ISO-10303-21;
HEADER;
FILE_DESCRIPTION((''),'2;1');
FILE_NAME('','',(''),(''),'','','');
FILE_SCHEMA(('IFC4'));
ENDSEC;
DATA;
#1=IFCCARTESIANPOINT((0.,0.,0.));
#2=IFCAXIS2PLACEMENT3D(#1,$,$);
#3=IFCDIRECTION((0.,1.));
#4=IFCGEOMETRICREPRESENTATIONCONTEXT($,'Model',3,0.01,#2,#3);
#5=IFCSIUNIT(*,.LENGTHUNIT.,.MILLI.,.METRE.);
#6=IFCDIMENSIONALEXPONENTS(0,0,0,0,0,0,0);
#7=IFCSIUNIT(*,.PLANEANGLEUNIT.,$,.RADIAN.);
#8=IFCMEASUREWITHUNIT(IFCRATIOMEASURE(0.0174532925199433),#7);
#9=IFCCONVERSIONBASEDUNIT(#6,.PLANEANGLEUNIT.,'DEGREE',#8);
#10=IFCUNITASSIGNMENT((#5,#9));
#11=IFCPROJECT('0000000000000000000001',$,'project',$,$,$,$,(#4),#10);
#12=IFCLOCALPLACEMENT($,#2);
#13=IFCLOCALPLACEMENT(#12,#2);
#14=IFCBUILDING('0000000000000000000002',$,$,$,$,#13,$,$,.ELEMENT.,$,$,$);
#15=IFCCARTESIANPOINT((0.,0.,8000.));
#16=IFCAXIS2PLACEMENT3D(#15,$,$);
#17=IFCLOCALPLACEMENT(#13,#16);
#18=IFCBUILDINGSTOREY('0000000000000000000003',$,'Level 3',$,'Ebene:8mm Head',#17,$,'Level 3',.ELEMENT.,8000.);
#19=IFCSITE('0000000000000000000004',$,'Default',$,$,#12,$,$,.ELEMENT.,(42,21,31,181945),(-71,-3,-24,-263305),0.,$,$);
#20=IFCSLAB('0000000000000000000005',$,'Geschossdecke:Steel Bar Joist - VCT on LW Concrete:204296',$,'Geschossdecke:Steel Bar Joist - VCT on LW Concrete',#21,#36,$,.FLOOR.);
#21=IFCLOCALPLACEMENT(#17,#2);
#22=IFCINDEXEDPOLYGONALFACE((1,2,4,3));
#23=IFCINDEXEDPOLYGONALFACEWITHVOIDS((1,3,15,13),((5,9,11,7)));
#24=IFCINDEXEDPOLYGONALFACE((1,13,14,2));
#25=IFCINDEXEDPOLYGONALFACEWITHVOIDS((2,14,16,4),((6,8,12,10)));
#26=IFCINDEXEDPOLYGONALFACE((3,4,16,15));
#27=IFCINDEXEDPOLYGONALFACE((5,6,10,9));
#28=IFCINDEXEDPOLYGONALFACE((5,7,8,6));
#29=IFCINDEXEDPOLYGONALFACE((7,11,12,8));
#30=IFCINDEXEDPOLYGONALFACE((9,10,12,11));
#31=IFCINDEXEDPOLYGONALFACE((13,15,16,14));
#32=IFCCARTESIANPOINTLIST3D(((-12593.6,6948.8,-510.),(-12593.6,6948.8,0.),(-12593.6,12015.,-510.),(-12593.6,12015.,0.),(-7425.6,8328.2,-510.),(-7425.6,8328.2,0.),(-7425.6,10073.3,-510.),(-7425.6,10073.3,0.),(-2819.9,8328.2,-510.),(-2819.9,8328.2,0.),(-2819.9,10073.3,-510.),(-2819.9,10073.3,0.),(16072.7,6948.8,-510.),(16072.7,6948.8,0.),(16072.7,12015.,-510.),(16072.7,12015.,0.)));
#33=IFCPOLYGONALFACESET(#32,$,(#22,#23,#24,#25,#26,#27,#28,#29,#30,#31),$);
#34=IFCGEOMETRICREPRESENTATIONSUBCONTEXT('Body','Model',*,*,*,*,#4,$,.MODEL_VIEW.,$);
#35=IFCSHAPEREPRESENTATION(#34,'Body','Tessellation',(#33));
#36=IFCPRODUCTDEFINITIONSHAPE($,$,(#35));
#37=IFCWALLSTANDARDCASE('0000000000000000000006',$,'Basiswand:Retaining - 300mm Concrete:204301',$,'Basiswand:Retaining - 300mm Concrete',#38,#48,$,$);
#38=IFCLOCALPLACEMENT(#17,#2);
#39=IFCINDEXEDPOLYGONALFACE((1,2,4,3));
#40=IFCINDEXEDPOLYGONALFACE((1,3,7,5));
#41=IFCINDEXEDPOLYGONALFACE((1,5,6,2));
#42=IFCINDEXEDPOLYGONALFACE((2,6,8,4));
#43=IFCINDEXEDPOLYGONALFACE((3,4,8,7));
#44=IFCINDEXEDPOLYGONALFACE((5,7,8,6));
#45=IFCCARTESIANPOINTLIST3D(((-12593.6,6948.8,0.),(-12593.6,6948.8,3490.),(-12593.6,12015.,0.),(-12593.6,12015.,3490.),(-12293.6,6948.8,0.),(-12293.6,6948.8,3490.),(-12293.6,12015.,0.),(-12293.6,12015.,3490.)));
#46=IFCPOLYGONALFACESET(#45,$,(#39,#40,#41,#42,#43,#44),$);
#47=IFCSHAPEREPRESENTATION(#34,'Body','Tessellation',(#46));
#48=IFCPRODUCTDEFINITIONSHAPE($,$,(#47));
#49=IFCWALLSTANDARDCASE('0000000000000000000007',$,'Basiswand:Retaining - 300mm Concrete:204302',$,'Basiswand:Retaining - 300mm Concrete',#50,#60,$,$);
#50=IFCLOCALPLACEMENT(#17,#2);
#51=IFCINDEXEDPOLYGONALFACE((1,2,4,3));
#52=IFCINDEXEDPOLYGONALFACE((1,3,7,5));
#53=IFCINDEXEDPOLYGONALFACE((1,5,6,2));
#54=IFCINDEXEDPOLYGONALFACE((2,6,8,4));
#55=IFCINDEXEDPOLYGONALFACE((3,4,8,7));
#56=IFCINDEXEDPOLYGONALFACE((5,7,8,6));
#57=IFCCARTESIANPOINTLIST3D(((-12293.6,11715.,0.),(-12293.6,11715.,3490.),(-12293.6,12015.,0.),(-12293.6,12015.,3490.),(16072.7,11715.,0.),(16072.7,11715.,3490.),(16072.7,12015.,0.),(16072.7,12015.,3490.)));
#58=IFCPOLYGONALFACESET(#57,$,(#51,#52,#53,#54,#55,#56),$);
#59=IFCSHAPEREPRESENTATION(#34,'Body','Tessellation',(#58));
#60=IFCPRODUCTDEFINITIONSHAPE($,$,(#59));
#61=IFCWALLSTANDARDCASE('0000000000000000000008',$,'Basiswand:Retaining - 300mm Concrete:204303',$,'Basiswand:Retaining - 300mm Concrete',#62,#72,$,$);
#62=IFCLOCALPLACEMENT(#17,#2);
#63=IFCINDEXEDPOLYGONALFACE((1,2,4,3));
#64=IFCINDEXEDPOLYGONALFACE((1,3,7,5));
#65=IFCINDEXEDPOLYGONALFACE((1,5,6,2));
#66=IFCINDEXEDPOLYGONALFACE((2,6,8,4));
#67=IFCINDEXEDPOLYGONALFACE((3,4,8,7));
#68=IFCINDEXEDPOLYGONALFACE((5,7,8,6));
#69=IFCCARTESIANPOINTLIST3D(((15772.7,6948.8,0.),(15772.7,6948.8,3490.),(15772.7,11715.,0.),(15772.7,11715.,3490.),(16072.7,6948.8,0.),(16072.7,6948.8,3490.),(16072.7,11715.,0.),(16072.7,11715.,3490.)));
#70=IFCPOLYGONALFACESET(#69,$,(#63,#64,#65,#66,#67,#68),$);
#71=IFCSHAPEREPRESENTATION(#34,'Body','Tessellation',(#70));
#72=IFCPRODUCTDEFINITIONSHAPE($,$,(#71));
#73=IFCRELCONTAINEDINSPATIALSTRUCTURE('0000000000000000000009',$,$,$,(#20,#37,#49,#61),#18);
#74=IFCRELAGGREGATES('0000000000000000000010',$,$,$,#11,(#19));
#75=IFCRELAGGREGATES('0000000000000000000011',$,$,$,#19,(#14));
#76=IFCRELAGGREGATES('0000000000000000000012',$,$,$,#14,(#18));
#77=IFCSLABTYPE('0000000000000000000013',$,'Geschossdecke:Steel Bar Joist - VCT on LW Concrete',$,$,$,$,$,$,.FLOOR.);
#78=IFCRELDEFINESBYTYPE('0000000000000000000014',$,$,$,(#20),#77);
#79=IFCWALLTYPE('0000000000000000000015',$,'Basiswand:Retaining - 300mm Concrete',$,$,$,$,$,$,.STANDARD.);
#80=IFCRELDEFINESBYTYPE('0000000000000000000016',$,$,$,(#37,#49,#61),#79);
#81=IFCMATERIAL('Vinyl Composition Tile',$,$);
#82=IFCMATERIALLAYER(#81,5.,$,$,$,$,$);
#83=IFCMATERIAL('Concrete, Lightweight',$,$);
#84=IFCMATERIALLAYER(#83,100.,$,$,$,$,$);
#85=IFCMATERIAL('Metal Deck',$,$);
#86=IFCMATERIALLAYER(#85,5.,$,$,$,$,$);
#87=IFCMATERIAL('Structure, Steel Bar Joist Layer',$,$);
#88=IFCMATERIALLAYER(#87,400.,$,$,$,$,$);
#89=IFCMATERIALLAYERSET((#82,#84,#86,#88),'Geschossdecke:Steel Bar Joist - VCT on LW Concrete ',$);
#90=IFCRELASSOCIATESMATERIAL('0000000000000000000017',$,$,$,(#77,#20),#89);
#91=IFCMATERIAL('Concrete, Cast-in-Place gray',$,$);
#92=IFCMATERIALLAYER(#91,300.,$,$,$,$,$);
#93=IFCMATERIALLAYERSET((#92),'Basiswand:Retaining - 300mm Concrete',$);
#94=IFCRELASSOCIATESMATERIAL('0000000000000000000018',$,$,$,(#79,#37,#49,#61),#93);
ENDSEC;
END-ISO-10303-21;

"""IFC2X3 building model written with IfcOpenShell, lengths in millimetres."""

from ifc_helpers import new_model, entity, si_unit, converted_unit, direction, frame, frame_2d, origin, origin_2d_with_axis, place, context, subcontext, project, spatial, polyline, rectangle, extrude, clip, bounded_halfspace, material, layer, layer_set, layer_usage, type_object, element, save


model = new_model("IFC2X3")

# Units and contexts
model_context = context("Model", 3, precision=0.01, world=origin(), true_north=direction((0.0, 1.0)))
body_context = subcontext(model_context, "Body", "Model", "MODEL_VIEW")
ifc_project = project(units=[si_unit("LENGTHUNIT", "METRE", prefix="MILLI"), converted_unit("PLANEANGLEUNIT", "DEGREE", entity("IfcRatioMeasure", 0.0174532925199433), si_unit("PLANEANGLEUNIT", "RADIAN"), dimensions=[0, 0, 0, 0, 0, 0, 0])], contexts=[model_context])

# Site, building, storey
site_placement = place(None, origin())
site = spatial("IfcSite", under=ifc_project, at=site_placement, Name="Default", CompositionType="ELEMENT", RefLatitude=(42, 21, 31, 181945), RefLongitude=(-71, -3, -24, -263305), RefElevation=0.0)
building_placement = place(site_placement, origin())
building = spatial("IfcBuilding", under=site, at=building_placement, CompositionType="ELEMENT")
storey_placement = place(building_placement, frame((0.0, 0.0, 8000.0)))
storey = spatial("IfcBuildingStorey", under=building, at=storey_placement, Name="Level 3", ObjectType="Ebene:8mm Head", LongName="Level 3", CompositionType="ELEMENT", Elevation=8000.0)

# Slab, opening
ifc_material_1 = material(Name="Vinyl Composition Tile")
ifc_layer_1 = layer(ifc_material_1, 5.0)
ifc_material_2 = material(Name="Concrete, Lightweight")
ifc_layer_2 = layer(ifc_material_2, 100.0)
ifc_material_3 = material(Name="Metal Deck")
ifc_layer_3 = layer(ifc_material_3, 5.0)
ifc_material_4 = material(Name="Structure, Steel Bar Joist Layer")
ifc_layer_4 = layer(ifc_material_4, 400.0)
ifc_layer_set_1 = layer_set([ifc_layer_1, ifc_layer_2, ifc_layer_3, ifc_layer_4], Name="Geschossdecke:Steel Bar Joist - VCT on LW Concrete ")
ifc_layer_usage_1 = layer_usage(ifc_layer_set_1, "AXIS3", "POSITIVE", 0.0)
slab_type = type_object("IfcSlabType", Name="Geschossdecke:Steel Bar Joist - VCT on LW Concrete", PredefinedType="FLOOR", material=ifc_layer_set_1)
slab_placement = place(storey_placement, frame((-12593.6, 6948.8, -510.0)))
slab = element("IfcSlab", 1, at=slab_placement, inside=storey, type_object=slab_type, material=ifc_layer_usage_1, Name="Geschossdecke:Steel Bar Joist - VCT on LW Concrete:204296", ObjectType="Geschossdecke:Steel Bar Joist - VCT on LW Concrete", PredefinedType="FLOOR", context=body_context, shape_type="SweptSolid", body=[
    extrude(rectangle(XDim=5066.3, YDim=28666.3, at=frame_2d((0.0, 0.0), x_axis=(0.0, -1.0))), frame((14333.1, 2533.1, 510.0), z_axis=(0.0, 0.0, -1.0), x_axis=(-1.0, 0.0, 0.0)), (0.0, 0.0, 1.0), 510.0),
])
opening_placement = place(slab_placement, frame((7470.8, 2252.0, 510.0)))
element("IfcOpeningElement", 2, at=opening_placement, cuts=slab, ObjectType="Opening", context=body_context, shape_type="SweptSolid", body=[
    extrude(rectangle(XDim=4605.8, YDim=1745.1, at=origin_2d_with_axis()), frame((0.0, 0.0, 0.0), z_axis=(0.0, 0.0, -1.0), x_axis=(1.0, 0.0, 0.0)), (0.0, 0.0, 1.0), 510.0),
])

# Walls
ifc_material_5 = material(Name="Concrete, Cast-in-Place gray")
ifc_layer_5 = layer(ifc_material_5, 300.0)
ifc_layer_set_2 = layer_set([ifc_layer_5], Name="Basiswand:Retaining - 300mm Concrete")
ifc_layer_usage_2 = layer_usage(ifc_layer_set_2, "AXIS2", "NEGATIVE", 150.0)
wall_type = type_object("IfcWallType", Name="Basiswand:Retaining - 300mm Concrete", PredefinedType="STANDARD", material=ifc_layer_set_2)
wall_1_placement = place(storey_placement, frame((-12443.6, 6948.8, 0.0), z_axis=(0.0, 0.0, 1.0), x_axis=(0.0, 1.0, 0.0)))
element("IfcWallStandardCase", 3, at=wall_1_placement, inside=storey, type_object=wall_type, material=ifc_layer_usage_2, Name="Basiswand:Retaining - 300mm Concrete:204301", ObjectType="Basiswand:Retaining - 300mm Concrete", context=body_context, shape_type="Clipping", body=[
    clip(extrude(rectangle(XDim=5066.3, YDim=300.0, at=frame_2d((2533.1, 0.0), x_axis=(-1.0, 0.0))), origin(), (0.0, 0.0, 1.0), 3490.0), bounded_halfspace(frame((0.0, -150.0, 3490.0), z_axis=(0.0, 0.0, -1.0), x_axis=(-1.0, 0.0, 0.0)), True, frame((0.0, -150.0, 3490.0)), polyline([(0.0, 0.0), (4766.3, 0.0), (5066.3, 0.0), (5066.3, 300.0), (0.0, 300.0), (0.0, 0.0)]))),
])
ifc_layer_usage_3 = layer_usage(ifc_layer_set_2, "AXIS2", "NEGATIVE", 150.0)
wall_2_placement = place(storey_placement, frame((-12293.6, 11865.0, 0.0)))
element("IfcWallStandardCase", 4, at=wall_2_placement, inside=storey, type_object=wall_type, material=ifc_layer_usage_3, Name="Basiswand:Retaining - 300mm Concrete:204302", ObjectType="Basiswand:Retaining - 300mm Concrete", context=body_context, shape_type="Clipping", body=[
    clip(extrude(rectangle(XDim=28366.3, YDim=300.0, at=frame_2d((14183.1, 0.0), x_axis=(-1.0, 0.0))), origin(), (0.0, 0.0, 1.0), 3490.0), bounded_halfspace(frame((0.0, -150.0, 3490.0), z_axis=(0.0, 0.0, -1.0), x_axis=(0.0, -1.0, 0.0)), True, frame((0.0, -150.0, 3490.0)), polyline([(0.0, 0.0), (28066.3, 0.0), (28366.3, 0.0), (28366.3, 300.0), (0.0, 300.0), (0.0, 0.0)]))),
])
ifc_layer_usage_4 = layer_usage(ifc_layer_set_2, "AXIS2", "NEGATIVE", 150.0)
wall_3_placement = place(storey_placement, frame((15922.7, 11715.0, 0.0), z_axis=(0.0, 0.0, 1.0), x_axis=(0.0, -1.0, 0.0)))
element("IfcWallStandardCase", 5, at=wall_3_placement, inside=storey, type_object=wall_type, material=ifc_layer_usage_4, Name="Basiswand:Retaining - 300mm Concrete:204303", ObjectType="Basiswand:Retaining - 300mm Concrete", context=body_context, shape_type="Clipping", body=[
    clip(extrude(rectangle(XDim=4766.3, YDim=300.0, at=frame_2d((2383.1, 0.0), x_axis=(-1.0, 0.0))), origin(), (0.0, 0.0, 1.0), 3490.0), bounded_halfspace(frame((0.0, -150.0, 3490.0), z_axis=(0.0, 0.0, -1.0), x_axis=(1.0, 0.0, 0.0)), True, frame((0.0, -150.0, 3490.0)), polyline([(0.0, 0.0), (4766.3, 0.0), (4766.3, 300.0), (0.0, 300.0), (0.0, 0.0)]))),
])

save(model, "model.ifc")
